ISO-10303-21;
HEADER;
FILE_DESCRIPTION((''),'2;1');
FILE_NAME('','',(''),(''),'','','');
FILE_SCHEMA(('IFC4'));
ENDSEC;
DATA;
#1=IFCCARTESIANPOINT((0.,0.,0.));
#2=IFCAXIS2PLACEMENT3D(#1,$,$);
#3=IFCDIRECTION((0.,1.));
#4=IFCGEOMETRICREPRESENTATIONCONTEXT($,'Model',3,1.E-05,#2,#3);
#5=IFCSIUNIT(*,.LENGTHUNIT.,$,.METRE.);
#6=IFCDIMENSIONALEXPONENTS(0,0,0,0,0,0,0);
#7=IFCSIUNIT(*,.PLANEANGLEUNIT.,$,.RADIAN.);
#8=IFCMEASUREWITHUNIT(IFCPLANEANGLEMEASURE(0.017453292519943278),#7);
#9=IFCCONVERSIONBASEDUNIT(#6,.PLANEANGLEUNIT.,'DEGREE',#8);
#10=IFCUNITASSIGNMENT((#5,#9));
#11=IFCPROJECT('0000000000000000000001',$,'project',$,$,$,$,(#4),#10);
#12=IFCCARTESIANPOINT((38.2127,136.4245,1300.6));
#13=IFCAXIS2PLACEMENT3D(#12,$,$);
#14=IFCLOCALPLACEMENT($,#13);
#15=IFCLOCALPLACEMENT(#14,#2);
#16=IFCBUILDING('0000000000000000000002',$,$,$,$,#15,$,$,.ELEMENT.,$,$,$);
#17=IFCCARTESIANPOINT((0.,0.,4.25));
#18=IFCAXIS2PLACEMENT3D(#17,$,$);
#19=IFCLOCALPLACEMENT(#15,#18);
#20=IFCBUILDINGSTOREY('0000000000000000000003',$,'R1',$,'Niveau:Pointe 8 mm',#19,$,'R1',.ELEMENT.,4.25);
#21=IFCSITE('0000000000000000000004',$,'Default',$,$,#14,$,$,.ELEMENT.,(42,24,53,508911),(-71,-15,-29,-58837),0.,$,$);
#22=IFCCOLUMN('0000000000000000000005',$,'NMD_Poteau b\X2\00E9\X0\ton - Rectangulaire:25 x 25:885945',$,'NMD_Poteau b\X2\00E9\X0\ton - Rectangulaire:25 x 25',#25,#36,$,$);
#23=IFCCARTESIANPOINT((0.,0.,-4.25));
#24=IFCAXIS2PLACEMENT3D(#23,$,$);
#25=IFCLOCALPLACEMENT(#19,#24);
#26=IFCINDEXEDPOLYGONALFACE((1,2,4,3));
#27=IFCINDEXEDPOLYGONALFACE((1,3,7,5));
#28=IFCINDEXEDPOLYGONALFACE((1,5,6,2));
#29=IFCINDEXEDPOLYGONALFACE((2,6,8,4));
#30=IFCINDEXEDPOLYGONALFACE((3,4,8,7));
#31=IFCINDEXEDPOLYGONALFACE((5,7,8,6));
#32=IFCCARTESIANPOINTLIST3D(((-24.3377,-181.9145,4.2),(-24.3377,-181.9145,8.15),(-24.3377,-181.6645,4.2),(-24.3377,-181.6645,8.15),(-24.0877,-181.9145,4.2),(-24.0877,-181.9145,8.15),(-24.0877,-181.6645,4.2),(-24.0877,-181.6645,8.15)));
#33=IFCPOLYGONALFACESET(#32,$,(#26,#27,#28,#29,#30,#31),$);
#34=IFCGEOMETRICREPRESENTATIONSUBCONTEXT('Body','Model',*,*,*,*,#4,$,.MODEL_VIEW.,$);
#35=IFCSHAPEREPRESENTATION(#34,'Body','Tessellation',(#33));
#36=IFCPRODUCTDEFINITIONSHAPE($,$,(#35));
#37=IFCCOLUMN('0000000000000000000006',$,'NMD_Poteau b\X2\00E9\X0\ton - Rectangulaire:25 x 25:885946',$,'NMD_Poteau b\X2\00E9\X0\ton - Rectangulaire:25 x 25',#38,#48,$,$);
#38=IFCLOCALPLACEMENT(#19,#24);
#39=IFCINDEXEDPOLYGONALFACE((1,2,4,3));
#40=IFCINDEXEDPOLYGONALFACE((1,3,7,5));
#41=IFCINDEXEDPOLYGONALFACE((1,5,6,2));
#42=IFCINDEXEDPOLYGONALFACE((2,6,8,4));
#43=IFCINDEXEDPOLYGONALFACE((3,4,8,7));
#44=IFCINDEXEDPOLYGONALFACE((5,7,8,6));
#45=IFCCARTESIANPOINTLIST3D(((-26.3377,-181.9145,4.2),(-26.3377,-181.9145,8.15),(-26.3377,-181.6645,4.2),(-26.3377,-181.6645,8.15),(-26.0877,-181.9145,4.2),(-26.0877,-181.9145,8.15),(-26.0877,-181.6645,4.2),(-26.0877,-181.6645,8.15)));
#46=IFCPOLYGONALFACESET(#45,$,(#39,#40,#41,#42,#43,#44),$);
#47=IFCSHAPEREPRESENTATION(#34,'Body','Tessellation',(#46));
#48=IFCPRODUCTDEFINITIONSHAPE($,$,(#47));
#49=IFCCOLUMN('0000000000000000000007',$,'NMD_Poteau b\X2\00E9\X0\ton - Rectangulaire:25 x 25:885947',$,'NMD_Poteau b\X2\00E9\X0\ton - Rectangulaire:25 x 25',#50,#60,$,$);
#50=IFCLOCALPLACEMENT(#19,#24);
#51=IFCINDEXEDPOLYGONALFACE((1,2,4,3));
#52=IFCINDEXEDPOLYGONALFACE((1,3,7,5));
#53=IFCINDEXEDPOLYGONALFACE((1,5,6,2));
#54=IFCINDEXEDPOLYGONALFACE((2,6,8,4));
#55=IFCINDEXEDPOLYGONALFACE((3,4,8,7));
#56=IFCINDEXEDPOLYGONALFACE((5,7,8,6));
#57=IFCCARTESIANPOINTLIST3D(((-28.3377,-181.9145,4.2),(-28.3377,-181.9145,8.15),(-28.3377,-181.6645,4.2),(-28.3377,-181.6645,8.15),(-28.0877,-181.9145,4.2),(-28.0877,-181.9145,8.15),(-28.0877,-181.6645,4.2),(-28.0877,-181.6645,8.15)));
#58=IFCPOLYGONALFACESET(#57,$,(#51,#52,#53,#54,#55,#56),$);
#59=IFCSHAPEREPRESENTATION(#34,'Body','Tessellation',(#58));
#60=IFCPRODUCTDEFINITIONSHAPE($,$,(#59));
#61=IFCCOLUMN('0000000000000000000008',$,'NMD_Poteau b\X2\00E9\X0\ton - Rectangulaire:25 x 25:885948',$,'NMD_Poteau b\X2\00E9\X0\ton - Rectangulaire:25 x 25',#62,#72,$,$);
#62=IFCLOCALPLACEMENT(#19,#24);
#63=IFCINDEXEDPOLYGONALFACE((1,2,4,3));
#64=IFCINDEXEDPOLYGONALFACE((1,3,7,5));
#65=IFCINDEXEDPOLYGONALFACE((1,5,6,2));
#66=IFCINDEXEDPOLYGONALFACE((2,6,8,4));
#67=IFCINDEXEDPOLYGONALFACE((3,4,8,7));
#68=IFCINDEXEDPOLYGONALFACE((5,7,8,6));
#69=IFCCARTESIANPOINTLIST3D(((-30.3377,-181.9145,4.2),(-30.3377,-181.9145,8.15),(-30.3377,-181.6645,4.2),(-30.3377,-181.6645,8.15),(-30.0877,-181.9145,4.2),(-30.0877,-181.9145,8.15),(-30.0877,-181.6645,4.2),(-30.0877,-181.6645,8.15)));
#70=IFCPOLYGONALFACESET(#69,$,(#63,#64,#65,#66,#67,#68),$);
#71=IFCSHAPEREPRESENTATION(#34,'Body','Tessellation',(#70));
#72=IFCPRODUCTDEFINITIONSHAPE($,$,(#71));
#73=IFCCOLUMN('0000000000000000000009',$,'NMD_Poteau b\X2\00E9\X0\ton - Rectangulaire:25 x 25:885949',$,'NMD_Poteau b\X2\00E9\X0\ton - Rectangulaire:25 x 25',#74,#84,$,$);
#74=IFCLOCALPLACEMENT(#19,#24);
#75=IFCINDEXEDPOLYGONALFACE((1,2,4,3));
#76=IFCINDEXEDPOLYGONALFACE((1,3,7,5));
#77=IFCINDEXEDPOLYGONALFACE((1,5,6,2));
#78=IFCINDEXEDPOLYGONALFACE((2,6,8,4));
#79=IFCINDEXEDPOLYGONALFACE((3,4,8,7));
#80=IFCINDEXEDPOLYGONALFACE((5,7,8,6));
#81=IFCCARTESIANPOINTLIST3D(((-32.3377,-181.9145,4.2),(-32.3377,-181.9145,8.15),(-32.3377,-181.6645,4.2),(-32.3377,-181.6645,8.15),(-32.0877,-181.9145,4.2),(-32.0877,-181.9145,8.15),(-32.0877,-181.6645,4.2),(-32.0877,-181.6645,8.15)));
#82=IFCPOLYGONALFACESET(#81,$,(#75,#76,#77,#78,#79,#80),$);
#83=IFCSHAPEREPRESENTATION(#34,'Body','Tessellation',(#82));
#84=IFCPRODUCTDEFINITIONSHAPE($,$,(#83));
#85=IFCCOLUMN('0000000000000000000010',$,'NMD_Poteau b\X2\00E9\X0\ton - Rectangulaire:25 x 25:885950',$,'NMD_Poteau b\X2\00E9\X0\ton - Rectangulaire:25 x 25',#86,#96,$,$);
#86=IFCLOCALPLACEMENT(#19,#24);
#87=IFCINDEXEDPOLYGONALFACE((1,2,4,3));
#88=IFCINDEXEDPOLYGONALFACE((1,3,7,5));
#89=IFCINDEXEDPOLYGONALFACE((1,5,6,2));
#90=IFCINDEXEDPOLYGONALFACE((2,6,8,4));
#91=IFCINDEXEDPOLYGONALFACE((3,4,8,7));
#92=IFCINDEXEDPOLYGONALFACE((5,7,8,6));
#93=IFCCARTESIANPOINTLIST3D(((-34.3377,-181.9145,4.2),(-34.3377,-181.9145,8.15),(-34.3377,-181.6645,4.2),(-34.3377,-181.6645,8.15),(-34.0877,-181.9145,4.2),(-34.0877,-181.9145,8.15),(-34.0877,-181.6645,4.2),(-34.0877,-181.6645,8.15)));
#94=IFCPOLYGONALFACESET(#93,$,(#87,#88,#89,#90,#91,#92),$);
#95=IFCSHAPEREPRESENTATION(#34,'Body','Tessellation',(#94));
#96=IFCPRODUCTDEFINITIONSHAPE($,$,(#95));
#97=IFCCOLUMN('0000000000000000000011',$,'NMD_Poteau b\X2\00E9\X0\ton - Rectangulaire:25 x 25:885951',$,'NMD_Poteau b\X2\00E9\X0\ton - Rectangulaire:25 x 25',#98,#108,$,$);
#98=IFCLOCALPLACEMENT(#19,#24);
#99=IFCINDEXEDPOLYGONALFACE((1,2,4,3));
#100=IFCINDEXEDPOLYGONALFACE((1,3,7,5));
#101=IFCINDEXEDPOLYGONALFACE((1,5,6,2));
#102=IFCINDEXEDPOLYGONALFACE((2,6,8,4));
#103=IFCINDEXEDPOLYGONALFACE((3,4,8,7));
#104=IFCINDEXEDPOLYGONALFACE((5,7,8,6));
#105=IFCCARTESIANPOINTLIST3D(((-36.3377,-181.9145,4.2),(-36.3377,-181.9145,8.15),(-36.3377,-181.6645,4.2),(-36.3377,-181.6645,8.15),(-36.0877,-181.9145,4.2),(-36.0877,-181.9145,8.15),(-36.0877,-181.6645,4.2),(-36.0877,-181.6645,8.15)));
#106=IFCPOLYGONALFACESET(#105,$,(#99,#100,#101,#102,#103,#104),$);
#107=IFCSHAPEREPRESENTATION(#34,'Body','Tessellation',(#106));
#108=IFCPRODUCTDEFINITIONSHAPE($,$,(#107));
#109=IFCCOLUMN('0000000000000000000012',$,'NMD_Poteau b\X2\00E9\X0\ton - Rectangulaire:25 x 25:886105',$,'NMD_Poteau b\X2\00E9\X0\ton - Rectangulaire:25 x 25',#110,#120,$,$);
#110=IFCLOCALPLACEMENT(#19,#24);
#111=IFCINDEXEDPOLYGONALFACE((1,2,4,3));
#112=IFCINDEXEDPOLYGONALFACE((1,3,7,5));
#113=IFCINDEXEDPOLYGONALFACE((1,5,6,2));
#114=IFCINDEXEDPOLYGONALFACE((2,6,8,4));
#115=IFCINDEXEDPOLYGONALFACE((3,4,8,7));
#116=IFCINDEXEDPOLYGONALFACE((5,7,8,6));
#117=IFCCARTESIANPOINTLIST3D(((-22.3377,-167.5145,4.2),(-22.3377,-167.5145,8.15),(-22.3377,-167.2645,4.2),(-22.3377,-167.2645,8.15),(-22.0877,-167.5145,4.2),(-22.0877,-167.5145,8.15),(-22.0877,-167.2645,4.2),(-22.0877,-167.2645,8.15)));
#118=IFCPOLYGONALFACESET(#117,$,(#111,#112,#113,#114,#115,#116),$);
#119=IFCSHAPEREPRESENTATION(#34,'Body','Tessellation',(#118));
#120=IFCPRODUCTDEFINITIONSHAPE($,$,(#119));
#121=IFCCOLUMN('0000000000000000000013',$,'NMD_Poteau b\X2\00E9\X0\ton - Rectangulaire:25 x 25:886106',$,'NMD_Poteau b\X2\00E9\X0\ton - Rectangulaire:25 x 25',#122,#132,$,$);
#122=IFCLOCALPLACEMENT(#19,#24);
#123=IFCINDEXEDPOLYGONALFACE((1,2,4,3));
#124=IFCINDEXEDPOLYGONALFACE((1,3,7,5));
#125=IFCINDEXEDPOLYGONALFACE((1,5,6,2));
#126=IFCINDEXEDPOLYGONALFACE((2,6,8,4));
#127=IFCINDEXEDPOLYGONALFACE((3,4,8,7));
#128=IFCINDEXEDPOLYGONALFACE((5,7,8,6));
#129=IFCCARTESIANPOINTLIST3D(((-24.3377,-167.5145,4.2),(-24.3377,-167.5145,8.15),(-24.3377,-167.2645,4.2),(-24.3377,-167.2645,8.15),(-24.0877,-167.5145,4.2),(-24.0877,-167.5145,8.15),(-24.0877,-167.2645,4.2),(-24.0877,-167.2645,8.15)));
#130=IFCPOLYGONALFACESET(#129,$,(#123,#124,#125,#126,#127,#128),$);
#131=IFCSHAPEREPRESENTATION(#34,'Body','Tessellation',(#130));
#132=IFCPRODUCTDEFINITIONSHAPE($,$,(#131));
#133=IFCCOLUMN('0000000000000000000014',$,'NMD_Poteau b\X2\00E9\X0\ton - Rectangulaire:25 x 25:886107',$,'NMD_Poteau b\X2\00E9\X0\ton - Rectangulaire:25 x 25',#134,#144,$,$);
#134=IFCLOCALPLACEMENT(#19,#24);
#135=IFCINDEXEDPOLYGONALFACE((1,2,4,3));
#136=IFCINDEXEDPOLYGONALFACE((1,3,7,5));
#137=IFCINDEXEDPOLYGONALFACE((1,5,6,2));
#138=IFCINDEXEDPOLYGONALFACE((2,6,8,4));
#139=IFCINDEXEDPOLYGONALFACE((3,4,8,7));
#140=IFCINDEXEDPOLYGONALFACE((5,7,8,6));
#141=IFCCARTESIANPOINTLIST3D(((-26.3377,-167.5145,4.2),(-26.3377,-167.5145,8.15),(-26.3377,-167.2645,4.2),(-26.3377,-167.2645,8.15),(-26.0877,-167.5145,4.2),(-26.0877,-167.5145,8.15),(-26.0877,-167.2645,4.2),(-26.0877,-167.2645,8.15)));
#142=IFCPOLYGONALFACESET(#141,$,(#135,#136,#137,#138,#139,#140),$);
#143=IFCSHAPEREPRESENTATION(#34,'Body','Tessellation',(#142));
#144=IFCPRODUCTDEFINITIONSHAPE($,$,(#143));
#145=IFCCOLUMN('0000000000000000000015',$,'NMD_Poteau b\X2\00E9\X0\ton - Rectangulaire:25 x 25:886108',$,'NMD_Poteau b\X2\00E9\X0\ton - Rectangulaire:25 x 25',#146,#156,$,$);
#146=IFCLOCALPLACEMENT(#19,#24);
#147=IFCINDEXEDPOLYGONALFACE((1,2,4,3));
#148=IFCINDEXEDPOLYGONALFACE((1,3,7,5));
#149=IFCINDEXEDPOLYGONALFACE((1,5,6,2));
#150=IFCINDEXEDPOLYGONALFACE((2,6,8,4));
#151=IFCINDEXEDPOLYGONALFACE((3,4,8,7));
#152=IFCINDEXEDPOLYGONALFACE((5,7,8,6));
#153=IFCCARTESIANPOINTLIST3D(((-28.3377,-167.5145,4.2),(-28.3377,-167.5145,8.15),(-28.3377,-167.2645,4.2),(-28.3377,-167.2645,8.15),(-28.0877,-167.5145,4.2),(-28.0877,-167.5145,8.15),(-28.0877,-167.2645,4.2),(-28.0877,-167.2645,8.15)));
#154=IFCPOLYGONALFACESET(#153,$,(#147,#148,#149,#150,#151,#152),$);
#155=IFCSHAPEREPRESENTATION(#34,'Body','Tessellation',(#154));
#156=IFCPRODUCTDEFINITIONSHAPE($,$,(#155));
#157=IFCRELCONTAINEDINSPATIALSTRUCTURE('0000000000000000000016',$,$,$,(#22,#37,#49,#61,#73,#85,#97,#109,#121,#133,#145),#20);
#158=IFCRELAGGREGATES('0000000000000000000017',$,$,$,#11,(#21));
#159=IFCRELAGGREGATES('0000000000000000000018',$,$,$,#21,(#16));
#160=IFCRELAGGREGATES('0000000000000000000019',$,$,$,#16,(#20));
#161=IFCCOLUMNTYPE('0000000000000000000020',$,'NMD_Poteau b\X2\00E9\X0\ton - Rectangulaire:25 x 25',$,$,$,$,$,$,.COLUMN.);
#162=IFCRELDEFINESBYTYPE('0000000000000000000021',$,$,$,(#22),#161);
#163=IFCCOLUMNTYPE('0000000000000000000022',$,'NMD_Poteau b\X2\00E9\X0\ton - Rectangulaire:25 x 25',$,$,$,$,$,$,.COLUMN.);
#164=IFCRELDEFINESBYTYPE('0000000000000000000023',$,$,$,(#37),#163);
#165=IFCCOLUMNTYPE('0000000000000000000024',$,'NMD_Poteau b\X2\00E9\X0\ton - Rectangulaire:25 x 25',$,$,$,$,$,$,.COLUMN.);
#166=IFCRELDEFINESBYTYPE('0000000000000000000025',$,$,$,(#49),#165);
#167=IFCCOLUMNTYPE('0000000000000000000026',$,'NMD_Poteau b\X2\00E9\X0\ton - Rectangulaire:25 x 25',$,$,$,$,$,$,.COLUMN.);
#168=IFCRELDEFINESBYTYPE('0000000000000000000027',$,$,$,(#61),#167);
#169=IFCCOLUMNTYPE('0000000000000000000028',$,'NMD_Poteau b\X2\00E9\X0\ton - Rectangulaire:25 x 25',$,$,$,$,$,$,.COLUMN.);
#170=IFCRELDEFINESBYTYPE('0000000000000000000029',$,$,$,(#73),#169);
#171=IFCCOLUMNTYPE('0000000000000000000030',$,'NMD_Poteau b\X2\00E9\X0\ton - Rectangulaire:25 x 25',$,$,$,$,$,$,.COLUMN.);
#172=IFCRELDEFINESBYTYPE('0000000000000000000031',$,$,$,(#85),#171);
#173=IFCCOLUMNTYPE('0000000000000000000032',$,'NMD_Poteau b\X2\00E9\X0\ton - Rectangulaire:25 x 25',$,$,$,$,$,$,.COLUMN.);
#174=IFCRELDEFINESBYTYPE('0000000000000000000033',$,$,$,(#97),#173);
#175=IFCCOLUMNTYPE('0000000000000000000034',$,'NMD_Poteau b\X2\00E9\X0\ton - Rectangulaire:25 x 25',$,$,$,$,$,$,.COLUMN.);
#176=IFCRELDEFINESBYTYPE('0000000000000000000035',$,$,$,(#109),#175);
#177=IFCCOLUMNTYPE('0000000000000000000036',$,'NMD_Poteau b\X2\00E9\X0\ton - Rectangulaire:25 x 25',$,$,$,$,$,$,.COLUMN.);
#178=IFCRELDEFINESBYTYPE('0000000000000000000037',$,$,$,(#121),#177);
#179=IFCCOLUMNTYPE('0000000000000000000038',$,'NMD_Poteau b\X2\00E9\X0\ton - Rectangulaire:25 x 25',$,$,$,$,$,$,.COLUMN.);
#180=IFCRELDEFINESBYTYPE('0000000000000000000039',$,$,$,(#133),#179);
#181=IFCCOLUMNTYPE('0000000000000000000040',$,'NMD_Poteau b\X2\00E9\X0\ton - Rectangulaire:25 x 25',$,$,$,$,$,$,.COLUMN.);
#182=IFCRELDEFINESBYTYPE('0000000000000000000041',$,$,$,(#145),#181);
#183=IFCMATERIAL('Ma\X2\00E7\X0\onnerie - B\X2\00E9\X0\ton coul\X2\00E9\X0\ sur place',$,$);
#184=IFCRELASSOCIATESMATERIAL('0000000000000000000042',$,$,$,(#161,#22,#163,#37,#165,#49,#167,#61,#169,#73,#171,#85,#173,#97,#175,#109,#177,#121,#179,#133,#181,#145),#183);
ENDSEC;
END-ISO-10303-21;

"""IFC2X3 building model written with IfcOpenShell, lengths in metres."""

from ifc_helpers import new_model, entity, si_unit, converted_unit, direction, frame, frame_2d, origin, place, context, subcontext, project, spatial, rectangle, extrude, source, transform, mapped, material, type_object, type_shapes, element, save


model = new_model("IFC2X3")

# Units and contexts
model_context = context("Model", 3, precision=1e-05, world=origin(), true_north=direction((0.0, 1.0)))
body_context = subcontext(model_context, "Body", "Model", "MODEL_VIEW")
ifc_project = project(units=[si_unit("LENGTHUNIT", "METRE"), converted_unit("PLANEANGLEUNIT", "DEGREE", entity("IfcPlaneAngleMeasure", 0.017453292519943278), si_unit("PLANEANGLEUNIT", "RADIAN"), dimensions=[0, 0, 0, 0, 0, 0, 0])], contexts=[model_context])

# Site, building, storey
site_placement = place(None, frame((38.2127, 136.4245, 1300.6)))
site = spatial("IfcSite", under=ifc_project, at=site_placement, Name="Default", CompositionType="ELEMENT", RefLatitude=(42, 24, 53, 508911), RefLongitude=(-71, -15, -29, -58837), RefElevation=0.0)
building_placement = place(site_placement, origin())
building = spatial("IfcBuilding", under=site, at=building_placement, CompositionType="ELEMENT")
storey_placement = place(building_placement, frame((0.0, 0.0, 4.25)))
storey = spatial("IfcBuildingStorey", under=building, at=storey_placement, Name="R1", ObjectType="Niveau:Pointe 8 mm", LongName="R1", CompositionType="ELEMENT", Elevation=4.25)

# Columns
ifc_material = material(Name="Maçonnerie - Béton coulé sur place")
column_type_1 = type_object("IfcColumnType", Name="NMD_Poteau béton - Rectangulaire:25 x 25", PredefinedType="COLUMN", material=ifc_material)
shared_shape_1 = source(origin(), body_context, "Body", "SweptSolid", [
    extrude(rectangle(XDim=0.25, YDim=0.25, at=frame_2d((0.0, 0.0), x_axis=(1.0, 0.0))), frame((-24.2127, -181.7895, 4.2), z_axis=(0.0, 0.0, 1.0), x_axis=(-1.0, 0.0, 0.0)), (0.0, 0.0, 1.0), 3.95),
])
type_shapes(column_type_1, [shared_shape_1])
column_1_placement = place(storey_placement, frame((0.0, 0.0, -4.25)))
element("IfcColumn", 1, at=column_1_placement, inside=storey, type_object=column_type_1, material=ifc_material, Name="NMD_Poteau béton - Rectangulaire:25 x 25:885945", ObjectType="NMD_Poteau béton - Rectangulaire:25 x 25", context=body_context, shape_type="MappedRepresentation", body=[
    mapped(shared_shape_1, transform((0.0, 0.0, 0.0), scale=1.0)),
])
column_type_2 = type_object("IfcColumnType", Name="NMD_Poteau béton - Rectangulaire:25 x 25", PredefinedType="COLUMN", material=ifc_material)
shared_shape_2 = source(origin(), body_context, "Body", "SweptSolid", [
    extrude(rectangle(XDim=0.25, YDim=0.25, at=frame_2d((0.0, 0.0), x_axis=(1.0, 0.0))), frame((-26.2127, -181.7895, 4.2), z_axis=(0.0, 0.0, 1.0), x_axis=(-1.0, 0.0, 0.0)), (0.0, 0.0, 1.0), 3.95),
])
type_shapes(column_type_2, [shared_shape_2])
column_2_placement = place(storey_placement, frame((0.0, 0.0, -4.25)))
element("IfcColumn", 2, at=column_2_placement, inside=storey, type_object=column_type_2, material=ifc_material, Name="NMD_Poteau béton - Rectangulaire:25 x 25:885946", ObjectType="NMD_Poteau béton - Rectangulaire:25 x 25", context=body_context, shape_type="MappedRepresentation", body=[
    mapped(shared_shape_2, transform((0.0, 0.0, 0.0), scale=1.0)),
])
column_type_3 = type_object("IfcColumnType", Name="NMD_Poteau béton - Rectangulaire:25 x 25", PredefinedType="COLUMN", material=ifc_material)
shared_shape_3 = source(origin(), body_context, "Body", "SweptSolid", [
    extrude(rectangle(XDim=0.25, YDim=0.25, at=frame_2d((0.0, 0.0), x_axis=(1.0, 0.0))), frame((-28.2127, -181.7895, 4.2), z_axis=(0.0, 0.0, 1.0), x_axis=(-1.0, 0.0, 0.0)), (0.0, 0.0, 1.0), 3.95),
])
type_shapes(column_type_3, [shared_shape_3])
column_3_placement = place(storey_placement, frame((0.0, 0.0, -4.25)))
element("IfcColumn", 3, at=column_3_placement, inside=storey, type_object=column_type_3, material=ifc_material, Name="NMD_Poteau béton - Rectangulaire:25 x 25:885947", ObjectType="NMD_Poteau béton - Rectangulaire:25 x 25", context=body_context, shape_type="MappedRepresentation", body=[
    mapped(shared_shape_3, transform((0.0, 0.0, 0.0), scale=1.0)),
])
column_type_4 = type_object("IfcColumnType", Name="NMD_Poteau béton - Rectangulaire:25 x 25", PredefinedType="COLUMN", material=ifc_material)
shared_shape_4 = source(origin(), body_context, "Body", "SweptSolid", [
    extrude(rectangle(XDim=0.25, YDim=0.25, at=frame_2d((0.0, 0.0), x_axis=(1.0, 0.0))), frame((-30.2127, -181.7895, 4.2), z_axis=(0.0, 0.0, 1.0), x_axis=(-1.0, 0.0, 0.0)), (0.0, 0.0, 1.0), 3.95),
])
type_shapes(column_type_4, [shared_shape_4])
column_4_placement = place(storey_placement, frame((0.0, 0.0, -4.25)))
element("IfcColumn", 4, at=column_4_placement, inside=storey, type_object=column_type_4, material=ifc_material, Name="NMD_Poteau béton - Rectangulaire:25 x 25:885948", ObjectType="NMD_Poteau béton - Rectangulaire:25 x 25", context=body_context, shape_type="MappedRepresentation", body=[
    mapped(shared_shape_4, transform((0.0, 0.0, 0.0), scale=1.0)),
])
column_type_5 = type_object("IfcColumnType", Name="NMD_Poteau béton - Rectangulaire:25 x 25", PredefinedType="COLUMN", material=ifc_material)
shared_shape_5 = source(origin(), body_context, "Body", "SweptSolid", [
    extrude(rectangle(XDim=0.25, YDim=0.25, at=frame_2d((0.0, 0.0), x_axis=(1.0, 0.0))), frame((-32.2127, -181.7895, 4.2), z_axis=(0.0, 0.0, 1.0), x_axis=(-1.0, 0.0, 0.0)), (0.0, 0.0, 1.0), 3.95),
])
type_shapes(column_type_5, [shared_shape_5])
column_5_placement = place(storey_placement, frame((0.0, 0.0, -4.25)))
element("IfcColumn", 5, at=column_5_placement, inside=storey, type_object=column_type_5, material=ifc_material, Name="NMD_Poteau béton - Rectangulaire:25 x 25:885949", ObjectType="NMD_Poteau béton - Rectangulaire:25 x 25", context=body_context, shape_type="MappedRepresentation", body=[
    mapped(shared_shape_5, transform((0.0, 0.0, 0.0), scale=1.0)),
])
column_type_6 = type_object("IfcColumnType", Name="NMD_Poteau béton - Rectangulaire:25 x 25", PredefinedType="COLUMN", material=ifc_material)
shared_shape_6 = source(origin(), body_context, "Body", "SweptSolid", [
    extrude(rectangle(XDim=0.25, YDim=0.25, at=frame_2d((0.0, 0.0), x_axis=(1.0, 0.0))), frame((-34.2127, -181.7895, 4.2), z_axis=(0.0, 0.0, 1.0), x_axis=(-1.0, 0.0, 0.0)), (0.0, 0.0, 1.0), 3.95),
])
type_shapes(column_type_6, [shared_shape_6])
column_6_placement = place(storey_placement, frame((0.0, 0.0, -4.25)))
element("IfcColumn", 6, at=column_6_placement, inside=storey, type_object=column_type_6, material=ifc_material, Name="NMD_Poteau béton - Rectangulaire:25 x 25:885950", ObjectType="NMD_Poteau béton - Rectangulaire:25 x 25", context=body_context, shape_type="MappedRepresentation", body=[
    mapped(shared_shape_6, transform((0.0, 0.0, 0.0), scale=1.0)),
])
column_type_7 = type_object("IfcColumnType", Name="NMD_Poteau béton - Rectangulaire:25 x 25", PredefinedType="COLUMN", material=ifc_material)
shared_shape_7 = source(origin(), body_context, "Body", "SweptSolid", [
    extrude(rectangle(XDim=0.25, YDim=0.25, at=frame_2d((0.0, 0.0), x_axis=(1.0, 0.0))), frame((-36.2127, -181.7895, 4.2), z_axis=(0.0, 0.0, 1.0), x_axis=(-1.0, 0.0, 0.0)), (0.0, 0.0, 1.0), 3.95),
])
type_shapes(column_type_7, [shared_shape_7])
column_7_placement = place(storey_placement, frame((0.0, 0.0, -4.25)))
element("IfcColumn", 7, at=column_7_placement, inside=storey, type_object=column_type_7, material=ifc_material, Name="NMD_Poteau béton - Rectangulaire:25 x 25:885951", ObjectType="NMD_Poteau béton - Rectangulaire:25 x 25", context=body_context, shape_type="MappedRepresentation", body=[
    mapped(shared_shape_7, transform((0.0, 0.0, 0.0), scale=1.0)),
])
column_type_8 = type_object("IfcColumnType", Name="NMD_Poteau béton - Rectangulaire:25 x 25", PredefinedType="COLUMN", material=ifc_material)
shared_shape_8 = source(origin(), body_context, "Body", "SweptSolid", [
    extrude(rectangle(XDim=0.25, YDim=0.25, at=frame_2d((0.0, 0.0), x_axis=(1.0, 0.0))), frame((-22.2127, -167.3895, 4.2), z_axis=(0.0, 0.0, 1.0), x_axis=(-1.0, 0.0, 0.0)), (0.0, 0.0, 1.0), 3.95),
])
type_shapes(column_type_8, [shared_shape_8])
column_8_placement = place(storey_placement, frame((0.0, 0.0, -4.25)))
element("IfcColumn", 8, at=column_8_placement, inside=storey, type_object=column_type_8, material=ifc_material, Name="NMD_Poteau béton - Rectangulaire:25 x 25:886105", ObjectType="NMD_Poteau béton - Rectangulaire:25 x 25", context=body_context, shape_type="MappedRepresentation", body=[
    mapped(shared_shape_8, transform((0.0, 0.0, 0.0), scale=1.0)),
])
column_type_9 = type_object("IfcColumnType", Name="NMD_Poteau béton - Rectangulaire:25 x 25", PredefinedType="COLUMN", material=ifc_material)
shared_shape_9 = source(origin(), body_context, "Body", "SweptSolid", [
    extrude(rectangle(XDim=0.25, YDim=0.25, at=frame_2d((0.0, 0.0), x_axis=(1.0, 0.0))), frame((-24.2127, -167.3895, 4.2), z_axis=(0.0, 0.0, 1.0), x_axis=(-1.0, 0.0, 0.0)), (0.0, 0.0, 1.0), 3.95),
])
type_shapes(column_type_9, [shared_shape_9])
column_9_placement = place(storey_placement, frame((0.0, 0.0, -4.25)))
element("IfcColumn", 9, at=column_9_placement, inside=storey, type_object=column_type_9, material=ifc_material, Name="NMD_Poteau béton - Rectangulaire:25 x 25:886106", ObjectType="NMD_Poteau béton - Rectangulaire:25 x 25", context=body_context, shape_type="MappedRepresentation", body=[
    mapped(shared_shape_9, transform((0.0, 0.0, 0.0), scale=1.0)),
])
column_type_10 = type_object("IfcColumnType", Name="NMD_Poteau béton - Rectangulaire:25 x 25", PredefinedType="COLUMN", material=ifc_material)
shared_shape_10 = source(origin(), body_context, "Body", "SweptSolid", [
    extrude(rectangle(XDim=0.25, YDim=0.25, at=frame_2d((0.0, 0.0), x_axis=(1.0, 0.0))), frame((-26.2127, -167.3895, 4.2), z_axis=(0.0, 0.0, 1.0), x_axis=(-1.0, 0.0, 0.0)), (0.0, 0.0, 1.0), 3.95),
])
type_shapes(column_type_10, [shared_shape_10])
column_10_placement = place(storey_placement, frame((0.0, 0.0, -4.25)))
element("IfcColumn", 10, at=column_10_placement, inside=storey, type_object=column_type_10, material=ifc_material, Name="NMD_Poteau béton - Rectangulaire:25 x 25:886107", ObjectType="NMD_Poteau béton - Rectangulaire:25 x 25", context=body_context, shape_type="MappedRepresentation", body=[
    mapped(shared_shape_10, transform((0.0, 0.0, 0.0), scale=1.0)),
])
column_type_11 = type_object("IfcColumnType", Name="NMD_Poteau béton - Rectangulaire:25 x 25", PredefinedType="COLUMN", material=ifc_material)
shared_shape_11 = source(origin(), body_context, "Body", "SweptSolid", [
    extrude(rectangle(XDim=0.25, YDim=0.25, at=frame_2d((0.0, 0.0), x_axis=(1.0, 0.0))), frame((-28.2127, -167.3895, 4.2), z_axis=(0.0, 0.0, 1.0), x_axis=(-1.0, 0.0, 0.0)), (0.0, 0.0, 1.0), 3.95),
])
type_shapes(column_type_11, [shared_shape_11])
column_11_placement = place(storey_placement, frame((0.0, 0.0, -4.25)))
element("IfcColumn", 11, at=column_11_placement, inside=storey, type_object=column_type_11, material=ifc_material, Name="NMD_Poteau béton - Rectangulaire:25 x 25:886108", ObjectType="NMD_Poteau béton - Rectangulaire:25 x 25", context=body_context, shape_type="MappedRepresentation", body=[
    mapped(shared_shape_11, transform((0.0, 0.0, 0.0), scale=1.0)),
])

save(model, "model.ifc")
